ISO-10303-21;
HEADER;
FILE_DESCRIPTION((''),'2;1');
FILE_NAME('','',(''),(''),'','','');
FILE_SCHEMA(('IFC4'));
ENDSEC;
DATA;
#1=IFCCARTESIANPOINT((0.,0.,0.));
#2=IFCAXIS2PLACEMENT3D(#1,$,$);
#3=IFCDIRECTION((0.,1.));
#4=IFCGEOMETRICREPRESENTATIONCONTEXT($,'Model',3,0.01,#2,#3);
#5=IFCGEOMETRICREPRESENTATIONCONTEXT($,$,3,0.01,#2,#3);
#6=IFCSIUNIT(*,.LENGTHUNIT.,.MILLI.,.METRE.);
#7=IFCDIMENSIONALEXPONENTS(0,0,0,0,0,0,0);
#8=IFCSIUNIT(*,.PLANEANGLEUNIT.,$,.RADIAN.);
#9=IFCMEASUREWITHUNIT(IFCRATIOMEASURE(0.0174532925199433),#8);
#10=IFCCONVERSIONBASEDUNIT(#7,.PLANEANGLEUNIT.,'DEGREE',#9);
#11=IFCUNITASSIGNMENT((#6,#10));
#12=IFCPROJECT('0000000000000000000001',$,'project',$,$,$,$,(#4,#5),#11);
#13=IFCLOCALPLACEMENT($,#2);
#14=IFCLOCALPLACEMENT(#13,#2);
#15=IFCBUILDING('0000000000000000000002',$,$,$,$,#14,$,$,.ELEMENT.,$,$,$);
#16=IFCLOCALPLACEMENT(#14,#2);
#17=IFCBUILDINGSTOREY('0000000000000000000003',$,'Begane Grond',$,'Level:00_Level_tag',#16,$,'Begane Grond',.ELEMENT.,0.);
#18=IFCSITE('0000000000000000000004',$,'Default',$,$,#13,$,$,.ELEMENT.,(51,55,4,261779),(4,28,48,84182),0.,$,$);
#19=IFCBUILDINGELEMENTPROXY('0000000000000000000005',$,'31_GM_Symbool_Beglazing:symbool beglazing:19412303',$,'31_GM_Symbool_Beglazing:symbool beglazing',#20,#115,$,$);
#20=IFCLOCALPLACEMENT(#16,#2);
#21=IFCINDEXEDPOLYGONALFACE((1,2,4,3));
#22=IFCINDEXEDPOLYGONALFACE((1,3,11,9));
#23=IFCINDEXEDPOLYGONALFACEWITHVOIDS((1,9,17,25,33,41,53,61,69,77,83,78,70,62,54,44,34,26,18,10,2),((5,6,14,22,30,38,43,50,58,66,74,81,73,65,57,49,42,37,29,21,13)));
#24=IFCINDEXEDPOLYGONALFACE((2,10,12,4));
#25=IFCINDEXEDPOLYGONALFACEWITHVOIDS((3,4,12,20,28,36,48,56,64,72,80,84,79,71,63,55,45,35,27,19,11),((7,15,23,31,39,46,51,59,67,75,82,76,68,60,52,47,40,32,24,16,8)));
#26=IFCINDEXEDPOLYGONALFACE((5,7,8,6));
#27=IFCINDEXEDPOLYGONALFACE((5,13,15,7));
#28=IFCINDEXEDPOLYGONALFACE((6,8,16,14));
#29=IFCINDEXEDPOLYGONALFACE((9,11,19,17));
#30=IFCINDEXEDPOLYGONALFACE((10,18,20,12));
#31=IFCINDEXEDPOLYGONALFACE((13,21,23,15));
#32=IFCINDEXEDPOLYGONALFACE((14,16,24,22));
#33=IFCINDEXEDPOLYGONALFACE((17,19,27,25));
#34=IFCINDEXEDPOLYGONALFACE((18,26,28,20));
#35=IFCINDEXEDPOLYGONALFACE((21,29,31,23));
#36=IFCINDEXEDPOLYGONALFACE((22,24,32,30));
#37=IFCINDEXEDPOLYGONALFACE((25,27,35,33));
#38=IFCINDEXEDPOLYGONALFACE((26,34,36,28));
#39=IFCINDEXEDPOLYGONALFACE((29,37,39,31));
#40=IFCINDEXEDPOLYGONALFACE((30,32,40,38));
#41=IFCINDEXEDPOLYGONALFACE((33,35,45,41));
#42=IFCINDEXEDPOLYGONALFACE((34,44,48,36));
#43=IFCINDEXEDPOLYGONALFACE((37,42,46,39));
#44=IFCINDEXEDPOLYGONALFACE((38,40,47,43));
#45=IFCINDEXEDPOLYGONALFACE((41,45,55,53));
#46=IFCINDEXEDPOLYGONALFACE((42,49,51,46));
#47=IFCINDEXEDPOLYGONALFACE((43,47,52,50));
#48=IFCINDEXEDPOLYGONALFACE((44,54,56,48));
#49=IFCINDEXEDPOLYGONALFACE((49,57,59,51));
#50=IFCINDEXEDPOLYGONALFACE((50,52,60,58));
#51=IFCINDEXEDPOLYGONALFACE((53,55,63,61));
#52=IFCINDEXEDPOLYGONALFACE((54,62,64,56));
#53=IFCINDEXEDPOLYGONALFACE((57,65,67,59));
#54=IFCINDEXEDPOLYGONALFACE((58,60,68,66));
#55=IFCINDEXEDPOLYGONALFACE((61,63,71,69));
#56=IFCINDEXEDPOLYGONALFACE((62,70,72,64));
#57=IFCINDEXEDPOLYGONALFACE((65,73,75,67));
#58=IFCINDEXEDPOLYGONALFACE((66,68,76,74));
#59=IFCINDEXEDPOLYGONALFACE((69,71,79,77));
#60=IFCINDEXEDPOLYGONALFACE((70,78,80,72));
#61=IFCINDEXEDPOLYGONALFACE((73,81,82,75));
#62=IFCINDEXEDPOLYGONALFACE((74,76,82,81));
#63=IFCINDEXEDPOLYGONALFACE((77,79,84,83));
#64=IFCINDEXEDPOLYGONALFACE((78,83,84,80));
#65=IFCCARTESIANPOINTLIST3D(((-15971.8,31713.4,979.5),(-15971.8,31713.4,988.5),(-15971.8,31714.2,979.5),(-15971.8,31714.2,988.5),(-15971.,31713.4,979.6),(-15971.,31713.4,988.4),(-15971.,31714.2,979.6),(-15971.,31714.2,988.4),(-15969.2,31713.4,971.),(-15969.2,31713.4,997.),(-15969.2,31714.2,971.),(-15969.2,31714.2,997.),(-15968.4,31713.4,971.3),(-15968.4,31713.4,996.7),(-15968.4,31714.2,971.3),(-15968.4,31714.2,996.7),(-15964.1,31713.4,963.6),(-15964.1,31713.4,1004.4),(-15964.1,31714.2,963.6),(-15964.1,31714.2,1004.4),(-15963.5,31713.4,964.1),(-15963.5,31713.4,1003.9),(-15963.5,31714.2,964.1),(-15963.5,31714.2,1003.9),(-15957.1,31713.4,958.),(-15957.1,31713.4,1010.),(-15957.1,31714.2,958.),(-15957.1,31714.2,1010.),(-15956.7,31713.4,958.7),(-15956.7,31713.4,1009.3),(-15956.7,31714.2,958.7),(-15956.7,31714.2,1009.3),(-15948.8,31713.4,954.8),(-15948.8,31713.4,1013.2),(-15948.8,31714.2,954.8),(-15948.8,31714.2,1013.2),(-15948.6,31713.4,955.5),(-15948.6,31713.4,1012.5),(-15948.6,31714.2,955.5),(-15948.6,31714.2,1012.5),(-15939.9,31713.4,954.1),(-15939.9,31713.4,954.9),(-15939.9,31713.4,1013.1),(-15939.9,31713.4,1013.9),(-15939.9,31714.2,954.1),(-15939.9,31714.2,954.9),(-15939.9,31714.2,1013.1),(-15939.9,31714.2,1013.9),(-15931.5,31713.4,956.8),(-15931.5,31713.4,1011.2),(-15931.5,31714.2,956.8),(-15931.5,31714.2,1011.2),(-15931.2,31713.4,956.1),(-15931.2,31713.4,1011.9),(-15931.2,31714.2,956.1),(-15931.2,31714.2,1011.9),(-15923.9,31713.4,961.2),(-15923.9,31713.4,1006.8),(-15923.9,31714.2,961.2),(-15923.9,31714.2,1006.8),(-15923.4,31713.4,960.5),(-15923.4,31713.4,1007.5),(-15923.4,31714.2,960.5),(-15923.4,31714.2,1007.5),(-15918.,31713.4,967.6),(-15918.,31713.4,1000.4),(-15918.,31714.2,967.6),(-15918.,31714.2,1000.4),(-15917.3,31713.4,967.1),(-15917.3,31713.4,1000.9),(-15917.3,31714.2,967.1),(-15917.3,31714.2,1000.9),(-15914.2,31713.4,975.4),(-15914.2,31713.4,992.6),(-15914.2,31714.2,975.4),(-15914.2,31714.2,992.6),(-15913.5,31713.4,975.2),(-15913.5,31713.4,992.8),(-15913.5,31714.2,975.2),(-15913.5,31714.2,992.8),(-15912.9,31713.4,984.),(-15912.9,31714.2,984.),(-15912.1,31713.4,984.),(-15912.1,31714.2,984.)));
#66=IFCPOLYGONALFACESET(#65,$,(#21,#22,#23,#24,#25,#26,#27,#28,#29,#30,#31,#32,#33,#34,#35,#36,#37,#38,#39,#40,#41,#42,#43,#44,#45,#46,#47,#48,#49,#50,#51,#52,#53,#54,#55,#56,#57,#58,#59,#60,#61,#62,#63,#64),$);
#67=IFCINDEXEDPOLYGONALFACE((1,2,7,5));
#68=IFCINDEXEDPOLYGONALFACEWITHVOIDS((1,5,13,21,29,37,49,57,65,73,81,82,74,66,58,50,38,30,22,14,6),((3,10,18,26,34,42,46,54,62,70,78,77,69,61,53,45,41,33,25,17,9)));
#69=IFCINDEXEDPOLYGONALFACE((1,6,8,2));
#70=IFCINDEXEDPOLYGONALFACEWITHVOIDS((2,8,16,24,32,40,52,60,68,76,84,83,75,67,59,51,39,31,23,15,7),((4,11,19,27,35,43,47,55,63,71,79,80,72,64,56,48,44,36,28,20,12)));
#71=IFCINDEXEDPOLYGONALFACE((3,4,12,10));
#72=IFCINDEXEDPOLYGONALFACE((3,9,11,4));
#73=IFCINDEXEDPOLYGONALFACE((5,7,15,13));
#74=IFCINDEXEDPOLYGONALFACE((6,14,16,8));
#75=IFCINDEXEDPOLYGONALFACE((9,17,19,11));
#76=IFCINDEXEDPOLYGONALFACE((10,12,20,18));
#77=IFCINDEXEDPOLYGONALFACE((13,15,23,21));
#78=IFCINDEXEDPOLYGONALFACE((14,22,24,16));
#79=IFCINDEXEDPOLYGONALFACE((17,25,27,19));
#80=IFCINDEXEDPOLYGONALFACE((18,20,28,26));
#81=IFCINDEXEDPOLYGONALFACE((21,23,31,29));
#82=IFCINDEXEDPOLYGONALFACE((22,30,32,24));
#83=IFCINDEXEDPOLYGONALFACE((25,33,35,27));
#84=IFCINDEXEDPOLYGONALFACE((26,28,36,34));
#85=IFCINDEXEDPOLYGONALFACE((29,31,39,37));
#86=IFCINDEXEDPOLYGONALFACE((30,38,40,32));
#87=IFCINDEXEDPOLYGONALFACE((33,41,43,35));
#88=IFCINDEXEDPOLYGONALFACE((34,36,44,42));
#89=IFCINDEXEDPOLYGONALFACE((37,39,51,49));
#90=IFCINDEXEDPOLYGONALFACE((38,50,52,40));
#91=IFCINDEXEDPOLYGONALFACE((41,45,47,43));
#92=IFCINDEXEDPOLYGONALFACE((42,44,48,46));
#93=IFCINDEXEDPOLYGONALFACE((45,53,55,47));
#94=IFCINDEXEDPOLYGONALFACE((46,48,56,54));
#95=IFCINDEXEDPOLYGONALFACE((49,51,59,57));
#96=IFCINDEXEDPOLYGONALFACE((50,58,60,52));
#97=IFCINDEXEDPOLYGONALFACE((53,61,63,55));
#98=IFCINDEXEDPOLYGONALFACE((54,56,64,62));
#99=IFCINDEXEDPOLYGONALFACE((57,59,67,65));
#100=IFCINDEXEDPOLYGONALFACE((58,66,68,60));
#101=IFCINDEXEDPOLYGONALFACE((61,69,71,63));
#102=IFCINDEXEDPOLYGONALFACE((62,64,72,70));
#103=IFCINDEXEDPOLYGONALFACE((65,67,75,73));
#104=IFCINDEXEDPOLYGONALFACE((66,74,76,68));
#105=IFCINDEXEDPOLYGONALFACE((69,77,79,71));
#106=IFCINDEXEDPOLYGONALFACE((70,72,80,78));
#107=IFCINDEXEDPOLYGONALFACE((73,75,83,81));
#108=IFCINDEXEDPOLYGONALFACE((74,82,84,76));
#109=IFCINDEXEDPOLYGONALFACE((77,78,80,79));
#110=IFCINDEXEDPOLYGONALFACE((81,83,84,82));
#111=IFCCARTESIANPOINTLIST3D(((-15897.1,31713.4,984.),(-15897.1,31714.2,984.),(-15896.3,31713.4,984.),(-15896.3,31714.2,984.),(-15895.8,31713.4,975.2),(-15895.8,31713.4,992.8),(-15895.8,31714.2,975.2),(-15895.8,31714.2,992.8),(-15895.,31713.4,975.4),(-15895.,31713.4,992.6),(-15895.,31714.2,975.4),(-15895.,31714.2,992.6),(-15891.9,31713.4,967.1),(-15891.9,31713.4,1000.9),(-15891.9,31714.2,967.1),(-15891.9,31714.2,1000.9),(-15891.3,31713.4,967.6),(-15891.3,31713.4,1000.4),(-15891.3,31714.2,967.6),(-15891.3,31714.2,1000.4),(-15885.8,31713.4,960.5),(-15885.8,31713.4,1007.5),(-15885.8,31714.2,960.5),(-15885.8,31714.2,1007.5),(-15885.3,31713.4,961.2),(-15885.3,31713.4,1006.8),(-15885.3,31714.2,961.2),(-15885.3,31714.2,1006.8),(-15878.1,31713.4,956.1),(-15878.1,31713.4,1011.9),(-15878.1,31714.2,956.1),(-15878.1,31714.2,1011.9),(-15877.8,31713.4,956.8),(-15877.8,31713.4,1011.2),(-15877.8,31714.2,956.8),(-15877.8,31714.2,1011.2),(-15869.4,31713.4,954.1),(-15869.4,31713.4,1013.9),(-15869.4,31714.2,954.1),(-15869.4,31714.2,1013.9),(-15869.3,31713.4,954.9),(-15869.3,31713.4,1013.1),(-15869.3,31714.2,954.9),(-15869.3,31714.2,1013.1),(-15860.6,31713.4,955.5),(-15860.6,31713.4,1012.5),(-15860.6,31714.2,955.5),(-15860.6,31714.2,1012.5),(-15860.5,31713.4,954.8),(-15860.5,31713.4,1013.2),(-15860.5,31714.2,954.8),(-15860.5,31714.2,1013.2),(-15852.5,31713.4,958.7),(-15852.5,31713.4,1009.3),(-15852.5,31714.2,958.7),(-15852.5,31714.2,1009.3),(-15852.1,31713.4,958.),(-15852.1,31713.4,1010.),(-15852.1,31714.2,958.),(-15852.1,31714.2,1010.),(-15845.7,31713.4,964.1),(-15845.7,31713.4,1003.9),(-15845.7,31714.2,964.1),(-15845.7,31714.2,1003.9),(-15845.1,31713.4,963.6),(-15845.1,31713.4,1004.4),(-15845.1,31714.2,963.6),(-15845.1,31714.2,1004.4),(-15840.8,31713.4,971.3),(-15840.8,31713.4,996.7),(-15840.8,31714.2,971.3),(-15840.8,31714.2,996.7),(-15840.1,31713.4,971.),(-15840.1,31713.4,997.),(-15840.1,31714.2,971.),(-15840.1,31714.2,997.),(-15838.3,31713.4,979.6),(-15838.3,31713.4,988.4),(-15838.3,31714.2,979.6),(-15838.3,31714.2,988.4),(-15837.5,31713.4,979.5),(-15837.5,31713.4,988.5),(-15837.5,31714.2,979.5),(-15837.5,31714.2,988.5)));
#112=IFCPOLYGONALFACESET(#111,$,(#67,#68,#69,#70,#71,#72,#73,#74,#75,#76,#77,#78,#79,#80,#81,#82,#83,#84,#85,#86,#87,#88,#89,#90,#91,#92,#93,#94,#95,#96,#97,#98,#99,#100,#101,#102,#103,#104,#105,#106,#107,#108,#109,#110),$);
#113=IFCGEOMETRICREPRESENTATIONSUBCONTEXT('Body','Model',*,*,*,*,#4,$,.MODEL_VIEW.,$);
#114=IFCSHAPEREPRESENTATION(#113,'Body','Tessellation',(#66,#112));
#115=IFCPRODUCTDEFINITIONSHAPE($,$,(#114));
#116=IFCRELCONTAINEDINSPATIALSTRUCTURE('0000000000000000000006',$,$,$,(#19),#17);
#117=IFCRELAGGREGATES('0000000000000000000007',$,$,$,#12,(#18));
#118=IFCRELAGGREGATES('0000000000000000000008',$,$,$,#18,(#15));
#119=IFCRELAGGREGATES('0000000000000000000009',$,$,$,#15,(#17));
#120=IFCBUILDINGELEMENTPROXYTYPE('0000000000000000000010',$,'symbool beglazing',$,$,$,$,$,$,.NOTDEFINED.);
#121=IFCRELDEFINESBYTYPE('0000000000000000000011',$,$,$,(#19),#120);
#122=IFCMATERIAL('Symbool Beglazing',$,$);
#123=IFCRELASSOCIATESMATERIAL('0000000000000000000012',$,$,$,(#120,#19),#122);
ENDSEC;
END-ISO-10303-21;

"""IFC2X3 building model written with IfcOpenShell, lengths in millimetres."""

from ifc_helpers import new_model, entity, si_unit, converted_unit, direction, frame, frame_2d, origin, place, context, subcontext, project, spatial, hollow_circle, extrude, source, transform, mapped, material, type_object, type_shapes, element, save


model = new_model("IFC2X3")

# Units and contexts
model_context = context("Model", 3, precision=0.01, world=origin(), true_north=direction((0.0, 1.0)))
context_of_model = context(None, 3, precision=0.01, world=origin(), true_north=direction((0.0, 1.0)))
body_context = subcontext(model_context, "Body", "Model", "MODEL_VIEW")
ifc_project = project(units=[si_unit("LENGTHUNIT", "METRE", prefix="MILLI"), converted_unit("PLANEANGLEUNIT", "DEGREE", entity("IfcRatioMeasure", 0.0174532925199433), si_unit("PLANEANGLEUNIT", "RADIAN"), dimensions=[0, 0, 0, 0, 0, 0, 0])], contexts=[model_context, context_of_model])

# Site, building, storey
site_placement = place(None, origin())
site = spatial("IfcSite", under=ifc_project, at=site_placement, Name="Default", CompositionType="ELEMENT", RefLatitude=(51, 55, 4, 261779), RefLongitude=(4, 28, 48, 84182), RefElevation=0.0)
building_placement = place(site_placement, origin())
building = spatial("IfcBuilding", under=site, at=building_placement, CompositionType="ELEMENT")
storey_placement = place(building_placement, origin())
storey = spatial("IfcBuildingStorey", under=building, at=storey_placement, Name="Begane Grond", ObjectType="Level:00_Level_tag", LongName="Begane Grond", CompositionType="ELEMENT", Elevation=0.0)

# Building element proxy
ifc_material_1 = material(Name="Symbool Beglazing")
building_element_proxy_type_1 = type_object("IfcBuildingElementProxyType", Name="symbool beglazing", PredefinedType="NOTDEFINED", material=ifc_material_1)
shared_shape_1 = source(origin(), body_context, "Body", "SweptSolid", [
    extrude(hollow_circle(Radius=30.0, WallThickness=0.8, at=frame_2d((0.0, 0.0), x_axis=(1.0, 0.0))), frame((37.5, 0.0, 0.0), z_axis=(0.0, 0.0, 1.0), x_axis=(-1.0, 0.0, 0.0)), (0.0, 0.0, 1.0), 0.8),
    extrude(hollow_circle(Radius=30.0, WallThickness=0.8, at=frame_2d((0.0, 0.0), x_axis=(1.0, 0.0))), frame((-37.5, 0.0, 0.0)), (0.0, 0.0, 1.0), 0.8),
])
type_shapes(building_element_proxy_type_1, [shared_shape_1])
for number, where, z_axis, x_axis, name in (
    (1, (-15904.6, 31713.4, 984.0), (0.0, 1.0, 0.0), (-1.0, 0.0, 0.0), "31_GM_Symbool_Beglazing:symbool beglazing:19412303"),
):
    element("IfcBuildingElementProxy", number, at=place(storey_placement, frame(where, z_axis=z_axis, x_axis=x_axis)), inside=storey, type_object=building_element_proxy_type_1, material=ifc_material_1, Name=name, ObjectType="31_GM_Symbool_Beglazing:symbool beglazing", context=body_context, shape_type="MappedRepresentation", body=[
        mapped(shared_shape_1, transform((0.0, 0.0, 0.0), scale=1.0)),
    ])

save(model, "model.ifc")
